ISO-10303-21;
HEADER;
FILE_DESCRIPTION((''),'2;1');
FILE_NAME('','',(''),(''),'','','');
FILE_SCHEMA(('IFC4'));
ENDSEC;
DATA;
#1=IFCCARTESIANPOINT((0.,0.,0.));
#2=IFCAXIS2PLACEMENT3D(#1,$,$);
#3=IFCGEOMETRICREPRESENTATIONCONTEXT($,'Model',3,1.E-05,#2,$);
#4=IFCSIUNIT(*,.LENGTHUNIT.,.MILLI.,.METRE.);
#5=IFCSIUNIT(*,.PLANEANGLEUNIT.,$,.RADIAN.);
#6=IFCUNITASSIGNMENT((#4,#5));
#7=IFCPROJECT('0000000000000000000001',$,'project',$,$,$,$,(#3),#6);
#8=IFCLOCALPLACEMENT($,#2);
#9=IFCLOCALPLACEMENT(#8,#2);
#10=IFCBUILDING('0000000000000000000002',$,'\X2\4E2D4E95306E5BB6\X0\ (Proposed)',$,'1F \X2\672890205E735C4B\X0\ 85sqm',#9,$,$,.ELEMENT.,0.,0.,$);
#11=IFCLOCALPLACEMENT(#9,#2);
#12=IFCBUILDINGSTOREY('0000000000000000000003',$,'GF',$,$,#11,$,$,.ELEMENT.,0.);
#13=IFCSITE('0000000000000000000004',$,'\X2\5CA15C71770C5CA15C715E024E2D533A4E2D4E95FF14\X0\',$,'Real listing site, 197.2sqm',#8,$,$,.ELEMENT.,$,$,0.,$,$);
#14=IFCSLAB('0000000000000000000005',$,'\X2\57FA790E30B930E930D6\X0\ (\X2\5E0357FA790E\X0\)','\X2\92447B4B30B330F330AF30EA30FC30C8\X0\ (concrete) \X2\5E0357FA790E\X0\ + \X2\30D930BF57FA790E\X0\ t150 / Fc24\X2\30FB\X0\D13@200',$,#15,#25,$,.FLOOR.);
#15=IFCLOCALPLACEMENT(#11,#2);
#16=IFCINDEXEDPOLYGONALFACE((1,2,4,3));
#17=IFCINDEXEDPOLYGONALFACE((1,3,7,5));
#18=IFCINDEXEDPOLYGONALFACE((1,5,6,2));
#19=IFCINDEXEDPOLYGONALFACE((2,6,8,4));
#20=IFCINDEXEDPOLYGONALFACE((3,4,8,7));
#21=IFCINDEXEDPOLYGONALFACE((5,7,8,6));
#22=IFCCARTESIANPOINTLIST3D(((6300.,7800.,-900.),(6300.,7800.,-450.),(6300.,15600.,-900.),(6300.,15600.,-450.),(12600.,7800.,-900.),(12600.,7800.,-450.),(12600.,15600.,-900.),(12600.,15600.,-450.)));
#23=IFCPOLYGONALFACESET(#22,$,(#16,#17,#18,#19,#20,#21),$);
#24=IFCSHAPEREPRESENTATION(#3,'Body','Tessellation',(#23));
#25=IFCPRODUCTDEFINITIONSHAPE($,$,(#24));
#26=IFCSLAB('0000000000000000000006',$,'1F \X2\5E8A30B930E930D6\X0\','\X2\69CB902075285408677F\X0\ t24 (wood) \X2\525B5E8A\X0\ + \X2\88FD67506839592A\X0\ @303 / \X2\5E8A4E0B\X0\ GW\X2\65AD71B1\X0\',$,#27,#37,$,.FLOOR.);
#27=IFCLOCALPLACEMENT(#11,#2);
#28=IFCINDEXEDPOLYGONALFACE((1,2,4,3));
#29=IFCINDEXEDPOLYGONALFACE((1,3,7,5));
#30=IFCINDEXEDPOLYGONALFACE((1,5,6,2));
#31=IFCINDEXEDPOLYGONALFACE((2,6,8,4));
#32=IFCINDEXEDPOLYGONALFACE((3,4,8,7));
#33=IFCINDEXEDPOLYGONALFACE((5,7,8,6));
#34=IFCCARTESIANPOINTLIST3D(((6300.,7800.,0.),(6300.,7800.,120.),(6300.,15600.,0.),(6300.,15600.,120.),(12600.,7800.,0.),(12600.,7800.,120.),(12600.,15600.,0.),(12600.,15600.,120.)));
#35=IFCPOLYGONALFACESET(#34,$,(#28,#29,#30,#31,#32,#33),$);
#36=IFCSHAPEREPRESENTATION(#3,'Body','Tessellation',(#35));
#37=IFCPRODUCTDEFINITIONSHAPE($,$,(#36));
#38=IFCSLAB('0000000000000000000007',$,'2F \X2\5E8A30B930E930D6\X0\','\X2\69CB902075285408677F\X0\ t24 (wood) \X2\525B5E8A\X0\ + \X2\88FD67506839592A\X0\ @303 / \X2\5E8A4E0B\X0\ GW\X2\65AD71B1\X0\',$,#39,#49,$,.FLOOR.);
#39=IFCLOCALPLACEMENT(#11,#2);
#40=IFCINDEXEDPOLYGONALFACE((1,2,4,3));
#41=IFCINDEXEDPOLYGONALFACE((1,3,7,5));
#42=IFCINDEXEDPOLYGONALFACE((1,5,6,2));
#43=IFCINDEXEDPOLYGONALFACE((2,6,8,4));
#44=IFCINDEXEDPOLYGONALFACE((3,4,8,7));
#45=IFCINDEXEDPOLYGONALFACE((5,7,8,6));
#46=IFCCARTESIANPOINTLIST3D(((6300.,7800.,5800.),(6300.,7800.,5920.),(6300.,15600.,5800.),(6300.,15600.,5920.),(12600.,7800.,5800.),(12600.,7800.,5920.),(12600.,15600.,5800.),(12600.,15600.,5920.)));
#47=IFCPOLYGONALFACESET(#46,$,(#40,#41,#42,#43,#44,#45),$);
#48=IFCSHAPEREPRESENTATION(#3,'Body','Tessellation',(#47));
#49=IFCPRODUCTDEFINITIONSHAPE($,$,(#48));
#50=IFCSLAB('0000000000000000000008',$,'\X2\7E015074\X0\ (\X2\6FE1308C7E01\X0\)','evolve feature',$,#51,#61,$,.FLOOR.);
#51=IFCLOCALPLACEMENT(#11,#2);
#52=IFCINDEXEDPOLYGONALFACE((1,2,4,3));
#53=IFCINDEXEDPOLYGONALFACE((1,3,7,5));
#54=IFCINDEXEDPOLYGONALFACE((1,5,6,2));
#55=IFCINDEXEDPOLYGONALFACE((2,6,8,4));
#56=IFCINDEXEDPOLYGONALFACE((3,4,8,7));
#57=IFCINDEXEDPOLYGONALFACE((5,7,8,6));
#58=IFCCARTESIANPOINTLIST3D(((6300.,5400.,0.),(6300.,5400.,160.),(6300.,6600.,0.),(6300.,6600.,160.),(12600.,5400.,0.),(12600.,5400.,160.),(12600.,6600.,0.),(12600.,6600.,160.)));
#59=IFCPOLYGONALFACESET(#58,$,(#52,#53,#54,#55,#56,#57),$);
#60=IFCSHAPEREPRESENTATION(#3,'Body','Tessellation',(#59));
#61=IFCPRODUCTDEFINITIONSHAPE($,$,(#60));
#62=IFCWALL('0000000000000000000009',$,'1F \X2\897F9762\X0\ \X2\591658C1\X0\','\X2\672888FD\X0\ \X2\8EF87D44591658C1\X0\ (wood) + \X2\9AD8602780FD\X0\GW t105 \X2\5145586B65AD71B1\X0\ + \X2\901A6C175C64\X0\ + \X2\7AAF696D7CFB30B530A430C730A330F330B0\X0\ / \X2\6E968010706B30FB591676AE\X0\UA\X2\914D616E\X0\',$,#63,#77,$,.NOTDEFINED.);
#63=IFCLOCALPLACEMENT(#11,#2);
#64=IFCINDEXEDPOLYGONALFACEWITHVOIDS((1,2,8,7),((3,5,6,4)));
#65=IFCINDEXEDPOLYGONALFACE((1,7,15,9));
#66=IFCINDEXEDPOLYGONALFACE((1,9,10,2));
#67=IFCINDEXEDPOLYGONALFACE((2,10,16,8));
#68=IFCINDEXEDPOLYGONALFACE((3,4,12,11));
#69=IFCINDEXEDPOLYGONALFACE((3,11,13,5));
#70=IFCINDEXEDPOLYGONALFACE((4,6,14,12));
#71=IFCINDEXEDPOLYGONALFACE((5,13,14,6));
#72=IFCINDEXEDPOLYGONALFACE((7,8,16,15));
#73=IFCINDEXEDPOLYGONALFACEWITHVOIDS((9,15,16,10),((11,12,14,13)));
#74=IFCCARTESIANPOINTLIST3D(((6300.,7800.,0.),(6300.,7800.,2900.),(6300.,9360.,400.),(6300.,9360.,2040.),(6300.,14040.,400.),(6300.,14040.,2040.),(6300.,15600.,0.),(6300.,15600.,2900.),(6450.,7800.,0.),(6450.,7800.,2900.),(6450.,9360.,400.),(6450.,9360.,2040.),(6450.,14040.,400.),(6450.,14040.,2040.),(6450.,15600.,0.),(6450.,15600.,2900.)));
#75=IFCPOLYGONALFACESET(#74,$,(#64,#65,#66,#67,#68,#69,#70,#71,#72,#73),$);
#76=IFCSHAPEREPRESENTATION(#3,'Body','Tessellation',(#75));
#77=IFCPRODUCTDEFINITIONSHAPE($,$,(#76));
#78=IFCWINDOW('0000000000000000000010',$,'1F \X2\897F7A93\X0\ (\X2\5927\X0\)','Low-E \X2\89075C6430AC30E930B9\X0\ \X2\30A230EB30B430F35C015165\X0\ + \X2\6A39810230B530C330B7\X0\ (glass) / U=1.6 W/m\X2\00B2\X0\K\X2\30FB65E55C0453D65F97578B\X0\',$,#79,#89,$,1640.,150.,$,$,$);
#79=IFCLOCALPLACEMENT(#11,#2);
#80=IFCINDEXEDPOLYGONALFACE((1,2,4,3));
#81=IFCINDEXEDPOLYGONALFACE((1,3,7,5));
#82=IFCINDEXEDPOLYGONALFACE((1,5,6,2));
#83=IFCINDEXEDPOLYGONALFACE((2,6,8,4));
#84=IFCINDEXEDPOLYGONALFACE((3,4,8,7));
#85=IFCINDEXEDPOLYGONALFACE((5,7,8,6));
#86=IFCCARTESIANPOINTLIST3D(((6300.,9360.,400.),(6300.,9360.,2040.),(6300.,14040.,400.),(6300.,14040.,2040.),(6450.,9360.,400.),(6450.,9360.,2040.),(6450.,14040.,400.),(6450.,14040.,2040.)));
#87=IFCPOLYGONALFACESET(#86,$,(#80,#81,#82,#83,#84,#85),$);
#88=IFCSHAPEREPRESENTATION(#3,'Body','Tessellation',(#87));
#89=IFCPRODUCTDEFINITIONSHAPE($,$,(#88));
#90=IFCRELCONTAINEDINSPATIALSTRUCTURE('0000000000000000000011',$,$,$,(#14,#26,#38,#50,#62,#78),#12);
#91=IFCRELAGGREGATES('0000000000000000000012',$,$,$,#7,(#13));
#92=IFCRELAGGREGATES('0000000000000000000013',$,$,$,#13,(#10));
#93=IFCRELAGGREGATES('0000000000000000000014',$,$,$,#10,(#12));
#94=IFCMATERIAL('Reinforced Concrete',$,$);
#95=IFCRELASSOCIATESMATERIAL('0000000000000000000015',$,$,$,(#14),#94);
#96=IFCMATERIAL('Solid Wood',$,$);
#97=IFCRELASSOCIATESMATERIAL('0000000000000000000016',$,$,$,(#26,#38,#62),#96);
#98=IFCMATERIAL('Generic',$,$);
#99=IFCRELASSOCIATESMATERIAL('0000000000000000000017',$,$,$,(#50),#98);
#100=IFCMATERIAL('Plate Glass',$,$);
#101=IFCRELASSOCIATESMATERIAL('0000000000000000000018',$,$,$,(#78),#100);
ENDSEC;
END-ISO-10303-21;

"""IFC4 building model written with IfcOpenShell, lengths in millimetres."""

from ifc_helpers import new_model, si_unit, frame, frame_2d, origin, place, context, project, spatial, rectangle, extrude, material, element, fill, save


model = new_model("IFC4")

# Units and contexts
model_context = context("Model", 3, precision=1e-05, world=origin())
ifc_project = project(units=[si_unit("LENGTHUNIT", "METRE", prefix="MILLI"), si_unit("PLANEANGLEUNIT", "RADIAN")], contexts=[model_context])

# Site, building, storey
site_placement = place(None, origin())
site = spatial("IfcSite", under=ifc_project, at=site_placement, Name="岡山県岡山市中区中井４", ObjectType="Real listing site, 197.2sqm", CompositionType="ELEMENT", RefElevation=0.0)
building_placement = place(site_placement, origin())
building = spatial("IfcBuilding", under=site, at=building_placement, Name="中井の家 (Proposed)", ObjectType="1F 木造平屋 85sqm", CompositionType="ELEMENT", ElevationOfRefHeight=0.0, ElevationOfTerrain=0.0)
storey_placement = place(building_placement, origin())
storey = spatial("IfcBuildingStorey", under=building, at=storey_placement, Name="GF", CompositionType="ELEMENT", Elevation=0.0)

# Slabs
ifc_material_1 = material(Name="Reinforced Concrete")
slab_1_placement = place(storey_placement, frame((3150.0, 3900.0, -450.0)))
element("IfcSlab", 1, at=slab_1_placement, inside=storey, material=ifc_material_1, Name="基礎スラブ (布基礎)", Description="鉄筋コンクリート (concrete) 布基礎 + ベタ基礎 t150 / Fc24・D13@200", PredefinedType="FLOOR", context=model_context, shape_type="SweptSolid", body=[
    extrude(rectangle(XDim=6300.0, YDim=7800.0, at=frame_2d((3150.0, 3900.0))), frame((3150.0, 3900.0, -450.0)), (0.0, 0.0, 1.0), 450.0),
])
ifc_material_2 = material(Name="Solid Wood")
slab_2_placement = place(storey_placement, frame((3150.0, 3900.0, 0.0)))
element("IfcSlab", 2, at=slab_2_placement, inside=storey, material=ifc_material_2, Name="1F 床スラブ", Description="構造用合板 t24 (wood) 剛床 + 製材根太 @303 / 床下 GW断熱", PredefinedType="FLOOR", context=model_context, shape_type="SweptSolid", body=[
    extrude(rectangle(XDim=6300.0, YDim=7800.0, at=frame_2d((3150.0, 3900.0))), frame((3150.0, 3900.0, 0.0)), (0.0, 0.0, 1.0), 120.0),
])
slab_3_placement = place(storey_placement, frame((3150.0, 3900.0, 2900.0)))
element("IfcSlab", 3, at=slab_3_placement, inside=storey, material=ifc_material_2, Name="2F 床スラブ", Description="構造用合板 t24 (wood) 剛床 + 製材根太 @303 / 床下 GW断熱", PredefinedType="FLOOR", context=model_context, shape_type="SweptSolid", body=[
    extrude(rectangle(XDim=6300.0, YDim=7800.0, at=frame_2d((3150.0, 3900.0))), frame((3150.0, 3900.0, 2900.0)), (0.0, 0.0, 1.0), 120.0),
])
ifc_material_3 = material(Name="Generic")
slab_4_placement = place(storey_placement, frame((3150.0, 2700.0, 0.0)))
element("IfcSlab", 4, at=slab_4_placement, inside=storey, material=ifc_material_3, Name="縁側 (濡れ縁)", Description="evolve feature", PredefinedType="FLOOR", context=model_context, shape_type="SweptSolid", body=[
    extrude(rectangle(XDim=6300.0, YDim=1200.0, at=frame_2d((3150.0, 600.0))), frame((3150.0, 2700.0, 0.0)), (0.0, 0.0, 1.0), 160.0),
])

# Shared definitions
ifc_material_4 = material(Name="Plate Glass")

# Wall, opening, window
wall_1_placement = place(storey_placement, frame((3150.0, 3900.0, 0.0)))
wall_1 = element("IfcWall", 5, at=wall_1_placement, inside=storey, material=ifc_material_2, Name="1F 西面 外壁", Description="木製 軸組外壁 (wood) + 高性能GW t105 充填断熱 + 通気層 + 窯業系サイディング / 準耐火・外皮UA配慮", PredefinedType="NOTDEFINED", context=model_context, shape_type="SweptSolid", body=[
    extrude(rectangle(XDim=150.0, YDim=7800.0, at=frame_2d((75.0, 3900.0))), frame((3150.0, 3900.0, 0.0)), (0.0, 0.0, 1.0), 2900.0),
])
opening_1_placement = place(storey_placement, frame((3150.0, 4680.0, 200.0)))
opening_1 = element("IfcOpeningElement", 6, at=opening_1_placement, cuts=wall_1, PredefinedType="NOTDEFINED", context=model_context, shape_type="SweptSolid", body=[
    extrude(rectangle(XDim=150.0, YDim=4680.0, at=frame_2d((75.0, 2340.0))), frame((3150.0, 4680.0, 200.0)), (0.0, 0.0, 1.0), 1640.0),
])
window_1_placement = place(storey_placement, frame((3150.0, 4680.0, 200.0)))
window_1 = element("IfcWindow", 7, at=window_1_placement, inside=storey, material=ifc_material_4, Name="1F 西窓 (大)", Description="Low-E 複層ガラス アルゴン封入 + 樹脂サッシ (glass) / U=1.6 W/m²K・日射取得型", OverallHeight=1640.0, OverallWidth=150.0, context=model_context, shape_type="SweptSolid", body=[
    extrude(rectangle(XDim=150.0, YDim=4680.0, at=frame_2d((75.0, 2340.0))), frame((3150.0, 4680.0, 200.0)), (0.0, 0.0, 1.0), 1640.0),
])
fill(opening_1, window_1)

save(model, "model.ifc")
